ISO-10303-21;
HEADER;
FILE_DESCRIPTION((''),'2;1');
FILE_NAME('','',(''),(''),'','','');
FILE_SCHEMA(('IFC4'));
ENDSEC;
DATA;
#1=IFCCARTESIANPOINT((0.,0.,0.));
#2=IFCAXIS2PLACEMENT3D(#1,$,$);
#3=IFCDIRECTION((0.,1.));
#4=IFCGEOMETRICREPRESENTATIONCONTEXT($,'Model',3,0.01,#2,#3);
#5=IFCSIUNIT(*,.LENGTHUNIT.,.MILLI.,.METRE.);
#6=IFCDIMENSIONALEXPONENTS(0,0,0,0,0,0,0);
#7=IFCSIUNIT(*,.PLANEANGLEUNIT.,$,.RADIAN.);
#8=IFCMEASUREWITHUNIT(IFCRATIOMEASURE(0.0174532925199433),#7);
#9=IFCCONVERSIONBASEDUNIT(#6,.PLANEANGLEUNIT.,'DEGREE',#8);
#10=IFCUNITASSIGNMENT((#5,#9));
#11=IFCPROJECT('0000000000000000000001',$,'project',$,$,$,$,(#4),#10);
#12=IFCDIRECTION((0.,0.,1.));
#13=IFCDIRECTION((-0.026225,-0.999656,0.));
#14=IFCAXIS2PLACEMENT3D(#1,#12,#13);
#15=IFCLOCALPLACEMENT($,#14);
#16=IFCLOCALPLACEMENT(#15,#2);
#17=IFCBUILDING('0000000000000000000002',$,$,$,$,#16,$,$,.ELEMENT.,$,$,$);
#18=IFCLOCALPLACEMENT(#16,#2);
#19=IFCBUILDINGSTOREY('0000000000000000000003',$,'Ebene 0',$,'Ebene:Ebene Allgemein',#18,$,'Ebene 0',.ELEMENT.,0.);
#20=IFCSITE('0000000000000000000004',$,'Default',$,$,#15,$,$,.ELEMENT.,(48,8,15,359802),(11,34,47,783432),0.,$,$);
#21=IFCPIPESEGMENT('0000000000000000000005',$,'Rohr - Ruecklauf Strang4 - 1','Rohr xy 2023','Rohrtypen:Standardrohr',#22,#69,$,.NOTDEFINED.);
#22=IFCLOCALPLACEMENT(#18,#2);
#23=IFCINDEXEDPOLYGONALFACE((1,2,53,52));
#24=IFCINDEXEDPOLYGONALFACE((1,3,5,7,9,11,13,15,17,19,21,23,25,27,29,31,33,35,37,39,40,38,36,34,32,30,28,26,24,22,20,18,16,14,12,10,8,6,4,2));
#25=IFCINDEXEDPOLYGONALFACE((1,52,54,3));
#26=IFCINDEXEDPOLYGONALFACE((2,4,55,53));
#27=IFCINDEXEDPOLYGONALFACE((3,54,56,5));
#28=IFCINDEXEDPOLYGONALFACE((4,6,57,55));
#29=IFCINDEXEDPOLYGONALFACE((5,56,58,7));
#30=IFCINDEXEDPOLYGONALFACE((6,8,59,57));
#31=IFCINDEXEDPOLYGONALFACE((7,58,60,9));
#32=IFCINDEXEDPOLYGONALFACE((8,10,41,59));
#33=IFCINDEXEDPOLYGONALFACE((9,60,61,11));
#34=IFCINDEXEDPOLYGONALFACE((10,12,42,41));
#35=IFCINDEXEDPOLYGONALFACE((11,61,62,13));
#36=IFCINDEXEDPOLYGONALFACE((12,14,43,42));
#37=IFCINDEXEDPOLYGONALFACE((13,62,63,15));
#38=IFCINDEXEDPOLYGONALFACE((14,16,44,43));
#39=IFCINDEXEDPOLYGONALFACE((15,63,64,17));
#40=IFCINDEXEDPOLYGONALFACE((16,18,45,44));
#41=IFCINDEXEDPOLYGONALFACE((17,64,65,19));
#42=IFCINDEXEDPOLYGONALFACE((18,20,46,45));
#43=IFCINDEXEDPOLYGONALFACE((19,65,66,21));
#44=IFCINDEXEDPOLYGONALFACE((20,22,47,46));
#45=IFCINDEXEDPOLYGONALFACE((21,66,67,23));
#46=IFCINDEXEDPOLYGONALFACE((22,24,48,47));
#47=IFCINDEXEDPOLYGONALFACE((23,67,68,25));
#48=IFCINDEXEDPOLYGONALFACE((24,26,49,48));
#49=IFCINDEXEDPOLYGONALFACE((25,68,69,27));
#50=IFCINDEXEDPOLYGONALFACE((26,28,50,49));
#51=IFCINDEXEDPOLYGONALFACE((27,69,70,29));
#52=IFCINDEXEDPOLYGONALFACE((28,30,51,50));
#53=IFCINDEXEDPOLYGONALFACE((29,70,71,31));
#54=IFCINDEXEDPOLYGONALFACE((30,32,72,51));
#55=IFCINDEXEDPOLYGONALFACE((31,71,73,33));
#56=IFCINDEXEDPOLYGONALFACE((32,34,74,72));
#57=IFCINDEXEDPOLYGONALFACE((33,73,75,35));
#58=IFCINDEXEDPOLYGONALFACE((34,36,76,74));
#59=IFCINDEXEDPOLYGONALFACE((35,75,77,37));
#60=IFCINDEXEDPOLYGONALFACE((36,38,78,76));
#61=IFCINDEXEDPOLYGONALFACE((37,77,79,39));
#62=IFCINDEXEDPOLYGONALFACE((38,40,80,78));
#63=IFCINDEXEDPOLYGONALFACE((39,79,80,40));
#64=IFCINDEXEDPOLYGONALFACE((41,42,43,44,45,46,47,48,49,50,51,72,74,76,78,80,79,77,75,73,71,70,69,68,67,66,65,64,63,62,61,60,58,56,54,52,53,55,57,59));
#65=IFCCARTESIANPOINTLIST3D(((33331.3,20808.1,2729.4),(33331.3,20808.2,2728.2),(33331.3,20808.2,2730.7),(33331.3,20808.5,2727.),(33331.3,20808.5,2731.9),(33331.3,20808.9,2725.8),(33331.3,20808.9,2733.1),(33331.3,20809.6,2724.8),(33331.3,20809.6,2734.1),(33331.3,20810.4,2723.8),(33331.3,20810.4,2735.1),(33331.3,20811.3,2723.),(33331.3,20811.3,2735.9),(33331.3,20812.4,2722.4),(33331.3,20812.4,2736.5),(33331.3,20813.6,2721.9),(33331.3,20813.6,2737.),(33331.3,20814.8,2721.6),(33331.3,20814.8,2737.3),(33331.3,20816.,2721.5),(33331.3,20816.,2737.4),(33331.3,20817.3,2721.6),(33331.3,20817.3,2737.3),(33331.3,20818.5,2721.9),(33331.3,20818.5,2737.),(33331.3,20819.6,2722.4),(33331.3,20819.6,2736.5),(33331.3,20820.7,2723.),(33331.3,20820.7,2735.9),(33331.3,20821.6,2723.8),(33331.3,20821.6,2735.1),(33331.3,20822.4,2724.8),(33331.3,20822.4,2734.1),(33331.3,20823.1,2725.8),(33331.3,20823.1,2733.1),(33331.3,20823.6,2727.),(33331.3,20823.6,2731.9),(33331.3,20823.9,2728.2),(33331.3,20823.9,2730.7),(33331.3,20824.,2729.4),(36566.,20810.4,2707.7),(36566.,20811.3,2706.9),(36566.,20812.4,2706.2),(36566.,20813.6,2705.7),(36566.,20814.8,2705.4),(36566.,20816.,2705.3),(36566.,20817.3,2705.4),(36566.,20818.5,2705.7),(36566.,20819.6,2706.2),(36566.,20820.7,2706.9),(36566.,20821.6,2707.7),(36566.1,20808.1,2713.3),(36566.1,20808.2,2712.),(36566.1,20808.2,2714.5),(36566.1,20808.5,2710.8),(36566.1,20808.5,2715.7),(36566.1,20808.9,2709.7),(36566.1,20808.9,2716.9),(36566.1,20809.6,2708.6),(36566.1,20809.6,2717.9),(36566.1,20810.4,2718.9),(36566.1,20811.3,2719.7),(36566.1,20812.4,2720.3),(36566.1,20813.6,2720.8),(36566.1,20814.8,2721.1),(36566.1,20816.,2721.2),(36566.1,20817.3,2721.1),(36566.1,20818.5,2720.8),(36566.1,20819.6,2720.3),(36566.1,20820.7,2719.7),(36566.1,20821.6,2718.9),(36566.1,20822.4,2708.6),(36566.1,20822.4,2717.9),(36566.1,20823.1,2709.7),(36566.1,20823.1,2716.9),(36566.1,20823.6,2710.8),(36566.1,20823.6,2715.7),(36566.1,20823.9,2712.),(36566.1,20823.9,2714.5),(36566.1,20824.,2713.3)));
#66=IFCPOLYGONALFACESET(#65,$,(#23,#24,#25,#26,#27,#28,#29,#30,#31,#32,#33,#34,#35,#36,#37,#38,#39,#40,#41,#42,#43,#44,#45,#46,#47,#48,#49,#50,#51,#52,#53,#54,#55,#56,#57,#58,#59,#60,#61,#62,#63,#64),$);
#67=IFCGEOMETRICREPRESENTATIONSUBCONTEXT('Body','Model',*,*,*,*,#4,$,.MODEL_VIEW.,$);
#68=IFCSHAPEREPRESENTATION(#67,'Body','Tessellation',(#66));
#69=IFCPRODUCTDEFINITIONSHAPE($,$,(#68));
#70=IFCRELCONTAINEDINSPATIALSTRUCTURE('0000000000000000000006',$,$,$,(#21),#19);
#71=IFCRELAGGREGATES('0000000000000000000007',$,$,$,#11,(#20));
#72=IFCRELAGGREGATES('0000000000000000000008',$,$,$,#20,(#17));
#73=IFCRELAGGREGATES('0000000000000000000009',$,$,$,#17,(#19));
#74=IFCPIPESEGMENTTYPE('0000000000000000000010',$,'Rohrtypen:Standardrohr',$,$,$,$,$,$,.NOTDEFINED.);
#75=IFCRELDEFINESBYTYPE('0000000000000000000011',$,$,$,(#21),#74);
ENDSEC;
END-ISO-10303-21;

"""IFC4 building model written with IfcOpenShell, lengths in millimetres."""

from ifc_helpers import new_model, entity, si_unit, converted_unit, direction, frame, origin, place, context, subcontext, project, spatial, indexed_curve, outline, extrude, type_object, element, save


model = new_model("IFC4")

# Units and contexts
model_context = context("Model", 3, precision=0.01, world=origin(), true_north=direction((0.0, 1.0)))
body_context = subcontext(model_context, "Body", "Model", "MODEL_VIEW")
ifc_project = project(units=[si_unit("LENGTHUNIT", "METRE", prefix="MILLI"), converted_unit("PLANEANGLEUNIT", "DEGREE", entity("IfcRatioMeasure", 0.0174532925199433), si_unit("PLANEANGLEUNIT", "RADIAN"), dimensions=[0, 0, 0, 0, 0, 0, 0])], contexts=[model_context])

# Site, building, storey
site_placement = place(None, frame((0.0, 0.0, 0.0), z_axis=(0.0, 0.0, 1.0), x_axis=(-0.026225, -0.999656, 0.0)))
site = spatial("IfcSite", under=ifc_project, at=site_placement, Name="Default", CompositionType="ELEMENT", RefLatitude=(48, 8, 15, 359802), RefLongitude=(11, 34, 47, 783432), RefElevation=0.0)
building_placement = place(site_placement, origin())
building = spatial("IfcBuilding", under=site, at=building_placement, CompositionType="ELEMENT")
storey_placement = place(building_placement, origin())
storey = spatial("IfcBuildingStorey", under=building, at=storey_placement, Name="Ebene 0", ObjectType="Ebene:Ebene Allgemein", LongName="Ebene 0", CompositionType="ELEMENT", Elevation=0.0)

# Pipe segment
pipe_segment_type = type_object("IfcPipeSegmentType", Name="Rohrtypen:Standardrohr", PredefinedType="NOTDEFINED")
pipe_segment_1_placement = place(storey_placement, origin())
element("IfcPipeSegment", 1, at=pipe_segment_1_placement, inside=storey, type_object=pipe_segment_type, Name="Rohr - Ruecklauf Strang4 - 1", Description="Rohr xy 2023", ObjectType="Rohrtypen:Standardrohr", PredefinedType="NOTDEFINED", context=body_context, shape_type="SweptSolid", body=[
    extrude(outline(indexed_curve([(7.9, 0.0), (7.8, 1.2), (7.6, 2.5), (7.1, 3.6), (6.4, 4.7), (5.6, 5.6), (4.7, 6.4), (3.6, 7.1), (2.5, 7.6), (1.2, 7.8), (0.0, 7.9), (-1.2, 7.8), (-2.5, 7.6), (-3.6, 7.1), (-4.7, 6.4), (-5.6, 5.6), (-6.4, 4.7), (-7.1, 3.6), (-7.6, 2.5), (-7.8, 1.2), (-7.9, 0.0), (-7.8, -1.2), (-7.6, -2.5), (-7.1, -3.6), (-6.4, -4.7), (-5.6, -5.6), (-4.7, -6.4), (-3.6, -7.1), (-2.5, -7.6), (-1.2, -7.8), (0.0, -7.9), (1.2, -7.8), (2.5, -7.6), (3.6, -7.1), (4.7, -6.4), (5.6, -5.6), (6.4, -4.7), (7.1, -3.6), (7.6, -2.5), (7.8, -1.2), (7.9, 0.0)], self_intersect=False)), frame((36566.1, 20816.0, 2713.3), z_axis=(-0.999988, 0.0, 0.005), x_axis=(0.0, 1.0, 0.0)), (0.0, 0.0, 1.0), 3234.8),
])

save(model, "model.ifc")
